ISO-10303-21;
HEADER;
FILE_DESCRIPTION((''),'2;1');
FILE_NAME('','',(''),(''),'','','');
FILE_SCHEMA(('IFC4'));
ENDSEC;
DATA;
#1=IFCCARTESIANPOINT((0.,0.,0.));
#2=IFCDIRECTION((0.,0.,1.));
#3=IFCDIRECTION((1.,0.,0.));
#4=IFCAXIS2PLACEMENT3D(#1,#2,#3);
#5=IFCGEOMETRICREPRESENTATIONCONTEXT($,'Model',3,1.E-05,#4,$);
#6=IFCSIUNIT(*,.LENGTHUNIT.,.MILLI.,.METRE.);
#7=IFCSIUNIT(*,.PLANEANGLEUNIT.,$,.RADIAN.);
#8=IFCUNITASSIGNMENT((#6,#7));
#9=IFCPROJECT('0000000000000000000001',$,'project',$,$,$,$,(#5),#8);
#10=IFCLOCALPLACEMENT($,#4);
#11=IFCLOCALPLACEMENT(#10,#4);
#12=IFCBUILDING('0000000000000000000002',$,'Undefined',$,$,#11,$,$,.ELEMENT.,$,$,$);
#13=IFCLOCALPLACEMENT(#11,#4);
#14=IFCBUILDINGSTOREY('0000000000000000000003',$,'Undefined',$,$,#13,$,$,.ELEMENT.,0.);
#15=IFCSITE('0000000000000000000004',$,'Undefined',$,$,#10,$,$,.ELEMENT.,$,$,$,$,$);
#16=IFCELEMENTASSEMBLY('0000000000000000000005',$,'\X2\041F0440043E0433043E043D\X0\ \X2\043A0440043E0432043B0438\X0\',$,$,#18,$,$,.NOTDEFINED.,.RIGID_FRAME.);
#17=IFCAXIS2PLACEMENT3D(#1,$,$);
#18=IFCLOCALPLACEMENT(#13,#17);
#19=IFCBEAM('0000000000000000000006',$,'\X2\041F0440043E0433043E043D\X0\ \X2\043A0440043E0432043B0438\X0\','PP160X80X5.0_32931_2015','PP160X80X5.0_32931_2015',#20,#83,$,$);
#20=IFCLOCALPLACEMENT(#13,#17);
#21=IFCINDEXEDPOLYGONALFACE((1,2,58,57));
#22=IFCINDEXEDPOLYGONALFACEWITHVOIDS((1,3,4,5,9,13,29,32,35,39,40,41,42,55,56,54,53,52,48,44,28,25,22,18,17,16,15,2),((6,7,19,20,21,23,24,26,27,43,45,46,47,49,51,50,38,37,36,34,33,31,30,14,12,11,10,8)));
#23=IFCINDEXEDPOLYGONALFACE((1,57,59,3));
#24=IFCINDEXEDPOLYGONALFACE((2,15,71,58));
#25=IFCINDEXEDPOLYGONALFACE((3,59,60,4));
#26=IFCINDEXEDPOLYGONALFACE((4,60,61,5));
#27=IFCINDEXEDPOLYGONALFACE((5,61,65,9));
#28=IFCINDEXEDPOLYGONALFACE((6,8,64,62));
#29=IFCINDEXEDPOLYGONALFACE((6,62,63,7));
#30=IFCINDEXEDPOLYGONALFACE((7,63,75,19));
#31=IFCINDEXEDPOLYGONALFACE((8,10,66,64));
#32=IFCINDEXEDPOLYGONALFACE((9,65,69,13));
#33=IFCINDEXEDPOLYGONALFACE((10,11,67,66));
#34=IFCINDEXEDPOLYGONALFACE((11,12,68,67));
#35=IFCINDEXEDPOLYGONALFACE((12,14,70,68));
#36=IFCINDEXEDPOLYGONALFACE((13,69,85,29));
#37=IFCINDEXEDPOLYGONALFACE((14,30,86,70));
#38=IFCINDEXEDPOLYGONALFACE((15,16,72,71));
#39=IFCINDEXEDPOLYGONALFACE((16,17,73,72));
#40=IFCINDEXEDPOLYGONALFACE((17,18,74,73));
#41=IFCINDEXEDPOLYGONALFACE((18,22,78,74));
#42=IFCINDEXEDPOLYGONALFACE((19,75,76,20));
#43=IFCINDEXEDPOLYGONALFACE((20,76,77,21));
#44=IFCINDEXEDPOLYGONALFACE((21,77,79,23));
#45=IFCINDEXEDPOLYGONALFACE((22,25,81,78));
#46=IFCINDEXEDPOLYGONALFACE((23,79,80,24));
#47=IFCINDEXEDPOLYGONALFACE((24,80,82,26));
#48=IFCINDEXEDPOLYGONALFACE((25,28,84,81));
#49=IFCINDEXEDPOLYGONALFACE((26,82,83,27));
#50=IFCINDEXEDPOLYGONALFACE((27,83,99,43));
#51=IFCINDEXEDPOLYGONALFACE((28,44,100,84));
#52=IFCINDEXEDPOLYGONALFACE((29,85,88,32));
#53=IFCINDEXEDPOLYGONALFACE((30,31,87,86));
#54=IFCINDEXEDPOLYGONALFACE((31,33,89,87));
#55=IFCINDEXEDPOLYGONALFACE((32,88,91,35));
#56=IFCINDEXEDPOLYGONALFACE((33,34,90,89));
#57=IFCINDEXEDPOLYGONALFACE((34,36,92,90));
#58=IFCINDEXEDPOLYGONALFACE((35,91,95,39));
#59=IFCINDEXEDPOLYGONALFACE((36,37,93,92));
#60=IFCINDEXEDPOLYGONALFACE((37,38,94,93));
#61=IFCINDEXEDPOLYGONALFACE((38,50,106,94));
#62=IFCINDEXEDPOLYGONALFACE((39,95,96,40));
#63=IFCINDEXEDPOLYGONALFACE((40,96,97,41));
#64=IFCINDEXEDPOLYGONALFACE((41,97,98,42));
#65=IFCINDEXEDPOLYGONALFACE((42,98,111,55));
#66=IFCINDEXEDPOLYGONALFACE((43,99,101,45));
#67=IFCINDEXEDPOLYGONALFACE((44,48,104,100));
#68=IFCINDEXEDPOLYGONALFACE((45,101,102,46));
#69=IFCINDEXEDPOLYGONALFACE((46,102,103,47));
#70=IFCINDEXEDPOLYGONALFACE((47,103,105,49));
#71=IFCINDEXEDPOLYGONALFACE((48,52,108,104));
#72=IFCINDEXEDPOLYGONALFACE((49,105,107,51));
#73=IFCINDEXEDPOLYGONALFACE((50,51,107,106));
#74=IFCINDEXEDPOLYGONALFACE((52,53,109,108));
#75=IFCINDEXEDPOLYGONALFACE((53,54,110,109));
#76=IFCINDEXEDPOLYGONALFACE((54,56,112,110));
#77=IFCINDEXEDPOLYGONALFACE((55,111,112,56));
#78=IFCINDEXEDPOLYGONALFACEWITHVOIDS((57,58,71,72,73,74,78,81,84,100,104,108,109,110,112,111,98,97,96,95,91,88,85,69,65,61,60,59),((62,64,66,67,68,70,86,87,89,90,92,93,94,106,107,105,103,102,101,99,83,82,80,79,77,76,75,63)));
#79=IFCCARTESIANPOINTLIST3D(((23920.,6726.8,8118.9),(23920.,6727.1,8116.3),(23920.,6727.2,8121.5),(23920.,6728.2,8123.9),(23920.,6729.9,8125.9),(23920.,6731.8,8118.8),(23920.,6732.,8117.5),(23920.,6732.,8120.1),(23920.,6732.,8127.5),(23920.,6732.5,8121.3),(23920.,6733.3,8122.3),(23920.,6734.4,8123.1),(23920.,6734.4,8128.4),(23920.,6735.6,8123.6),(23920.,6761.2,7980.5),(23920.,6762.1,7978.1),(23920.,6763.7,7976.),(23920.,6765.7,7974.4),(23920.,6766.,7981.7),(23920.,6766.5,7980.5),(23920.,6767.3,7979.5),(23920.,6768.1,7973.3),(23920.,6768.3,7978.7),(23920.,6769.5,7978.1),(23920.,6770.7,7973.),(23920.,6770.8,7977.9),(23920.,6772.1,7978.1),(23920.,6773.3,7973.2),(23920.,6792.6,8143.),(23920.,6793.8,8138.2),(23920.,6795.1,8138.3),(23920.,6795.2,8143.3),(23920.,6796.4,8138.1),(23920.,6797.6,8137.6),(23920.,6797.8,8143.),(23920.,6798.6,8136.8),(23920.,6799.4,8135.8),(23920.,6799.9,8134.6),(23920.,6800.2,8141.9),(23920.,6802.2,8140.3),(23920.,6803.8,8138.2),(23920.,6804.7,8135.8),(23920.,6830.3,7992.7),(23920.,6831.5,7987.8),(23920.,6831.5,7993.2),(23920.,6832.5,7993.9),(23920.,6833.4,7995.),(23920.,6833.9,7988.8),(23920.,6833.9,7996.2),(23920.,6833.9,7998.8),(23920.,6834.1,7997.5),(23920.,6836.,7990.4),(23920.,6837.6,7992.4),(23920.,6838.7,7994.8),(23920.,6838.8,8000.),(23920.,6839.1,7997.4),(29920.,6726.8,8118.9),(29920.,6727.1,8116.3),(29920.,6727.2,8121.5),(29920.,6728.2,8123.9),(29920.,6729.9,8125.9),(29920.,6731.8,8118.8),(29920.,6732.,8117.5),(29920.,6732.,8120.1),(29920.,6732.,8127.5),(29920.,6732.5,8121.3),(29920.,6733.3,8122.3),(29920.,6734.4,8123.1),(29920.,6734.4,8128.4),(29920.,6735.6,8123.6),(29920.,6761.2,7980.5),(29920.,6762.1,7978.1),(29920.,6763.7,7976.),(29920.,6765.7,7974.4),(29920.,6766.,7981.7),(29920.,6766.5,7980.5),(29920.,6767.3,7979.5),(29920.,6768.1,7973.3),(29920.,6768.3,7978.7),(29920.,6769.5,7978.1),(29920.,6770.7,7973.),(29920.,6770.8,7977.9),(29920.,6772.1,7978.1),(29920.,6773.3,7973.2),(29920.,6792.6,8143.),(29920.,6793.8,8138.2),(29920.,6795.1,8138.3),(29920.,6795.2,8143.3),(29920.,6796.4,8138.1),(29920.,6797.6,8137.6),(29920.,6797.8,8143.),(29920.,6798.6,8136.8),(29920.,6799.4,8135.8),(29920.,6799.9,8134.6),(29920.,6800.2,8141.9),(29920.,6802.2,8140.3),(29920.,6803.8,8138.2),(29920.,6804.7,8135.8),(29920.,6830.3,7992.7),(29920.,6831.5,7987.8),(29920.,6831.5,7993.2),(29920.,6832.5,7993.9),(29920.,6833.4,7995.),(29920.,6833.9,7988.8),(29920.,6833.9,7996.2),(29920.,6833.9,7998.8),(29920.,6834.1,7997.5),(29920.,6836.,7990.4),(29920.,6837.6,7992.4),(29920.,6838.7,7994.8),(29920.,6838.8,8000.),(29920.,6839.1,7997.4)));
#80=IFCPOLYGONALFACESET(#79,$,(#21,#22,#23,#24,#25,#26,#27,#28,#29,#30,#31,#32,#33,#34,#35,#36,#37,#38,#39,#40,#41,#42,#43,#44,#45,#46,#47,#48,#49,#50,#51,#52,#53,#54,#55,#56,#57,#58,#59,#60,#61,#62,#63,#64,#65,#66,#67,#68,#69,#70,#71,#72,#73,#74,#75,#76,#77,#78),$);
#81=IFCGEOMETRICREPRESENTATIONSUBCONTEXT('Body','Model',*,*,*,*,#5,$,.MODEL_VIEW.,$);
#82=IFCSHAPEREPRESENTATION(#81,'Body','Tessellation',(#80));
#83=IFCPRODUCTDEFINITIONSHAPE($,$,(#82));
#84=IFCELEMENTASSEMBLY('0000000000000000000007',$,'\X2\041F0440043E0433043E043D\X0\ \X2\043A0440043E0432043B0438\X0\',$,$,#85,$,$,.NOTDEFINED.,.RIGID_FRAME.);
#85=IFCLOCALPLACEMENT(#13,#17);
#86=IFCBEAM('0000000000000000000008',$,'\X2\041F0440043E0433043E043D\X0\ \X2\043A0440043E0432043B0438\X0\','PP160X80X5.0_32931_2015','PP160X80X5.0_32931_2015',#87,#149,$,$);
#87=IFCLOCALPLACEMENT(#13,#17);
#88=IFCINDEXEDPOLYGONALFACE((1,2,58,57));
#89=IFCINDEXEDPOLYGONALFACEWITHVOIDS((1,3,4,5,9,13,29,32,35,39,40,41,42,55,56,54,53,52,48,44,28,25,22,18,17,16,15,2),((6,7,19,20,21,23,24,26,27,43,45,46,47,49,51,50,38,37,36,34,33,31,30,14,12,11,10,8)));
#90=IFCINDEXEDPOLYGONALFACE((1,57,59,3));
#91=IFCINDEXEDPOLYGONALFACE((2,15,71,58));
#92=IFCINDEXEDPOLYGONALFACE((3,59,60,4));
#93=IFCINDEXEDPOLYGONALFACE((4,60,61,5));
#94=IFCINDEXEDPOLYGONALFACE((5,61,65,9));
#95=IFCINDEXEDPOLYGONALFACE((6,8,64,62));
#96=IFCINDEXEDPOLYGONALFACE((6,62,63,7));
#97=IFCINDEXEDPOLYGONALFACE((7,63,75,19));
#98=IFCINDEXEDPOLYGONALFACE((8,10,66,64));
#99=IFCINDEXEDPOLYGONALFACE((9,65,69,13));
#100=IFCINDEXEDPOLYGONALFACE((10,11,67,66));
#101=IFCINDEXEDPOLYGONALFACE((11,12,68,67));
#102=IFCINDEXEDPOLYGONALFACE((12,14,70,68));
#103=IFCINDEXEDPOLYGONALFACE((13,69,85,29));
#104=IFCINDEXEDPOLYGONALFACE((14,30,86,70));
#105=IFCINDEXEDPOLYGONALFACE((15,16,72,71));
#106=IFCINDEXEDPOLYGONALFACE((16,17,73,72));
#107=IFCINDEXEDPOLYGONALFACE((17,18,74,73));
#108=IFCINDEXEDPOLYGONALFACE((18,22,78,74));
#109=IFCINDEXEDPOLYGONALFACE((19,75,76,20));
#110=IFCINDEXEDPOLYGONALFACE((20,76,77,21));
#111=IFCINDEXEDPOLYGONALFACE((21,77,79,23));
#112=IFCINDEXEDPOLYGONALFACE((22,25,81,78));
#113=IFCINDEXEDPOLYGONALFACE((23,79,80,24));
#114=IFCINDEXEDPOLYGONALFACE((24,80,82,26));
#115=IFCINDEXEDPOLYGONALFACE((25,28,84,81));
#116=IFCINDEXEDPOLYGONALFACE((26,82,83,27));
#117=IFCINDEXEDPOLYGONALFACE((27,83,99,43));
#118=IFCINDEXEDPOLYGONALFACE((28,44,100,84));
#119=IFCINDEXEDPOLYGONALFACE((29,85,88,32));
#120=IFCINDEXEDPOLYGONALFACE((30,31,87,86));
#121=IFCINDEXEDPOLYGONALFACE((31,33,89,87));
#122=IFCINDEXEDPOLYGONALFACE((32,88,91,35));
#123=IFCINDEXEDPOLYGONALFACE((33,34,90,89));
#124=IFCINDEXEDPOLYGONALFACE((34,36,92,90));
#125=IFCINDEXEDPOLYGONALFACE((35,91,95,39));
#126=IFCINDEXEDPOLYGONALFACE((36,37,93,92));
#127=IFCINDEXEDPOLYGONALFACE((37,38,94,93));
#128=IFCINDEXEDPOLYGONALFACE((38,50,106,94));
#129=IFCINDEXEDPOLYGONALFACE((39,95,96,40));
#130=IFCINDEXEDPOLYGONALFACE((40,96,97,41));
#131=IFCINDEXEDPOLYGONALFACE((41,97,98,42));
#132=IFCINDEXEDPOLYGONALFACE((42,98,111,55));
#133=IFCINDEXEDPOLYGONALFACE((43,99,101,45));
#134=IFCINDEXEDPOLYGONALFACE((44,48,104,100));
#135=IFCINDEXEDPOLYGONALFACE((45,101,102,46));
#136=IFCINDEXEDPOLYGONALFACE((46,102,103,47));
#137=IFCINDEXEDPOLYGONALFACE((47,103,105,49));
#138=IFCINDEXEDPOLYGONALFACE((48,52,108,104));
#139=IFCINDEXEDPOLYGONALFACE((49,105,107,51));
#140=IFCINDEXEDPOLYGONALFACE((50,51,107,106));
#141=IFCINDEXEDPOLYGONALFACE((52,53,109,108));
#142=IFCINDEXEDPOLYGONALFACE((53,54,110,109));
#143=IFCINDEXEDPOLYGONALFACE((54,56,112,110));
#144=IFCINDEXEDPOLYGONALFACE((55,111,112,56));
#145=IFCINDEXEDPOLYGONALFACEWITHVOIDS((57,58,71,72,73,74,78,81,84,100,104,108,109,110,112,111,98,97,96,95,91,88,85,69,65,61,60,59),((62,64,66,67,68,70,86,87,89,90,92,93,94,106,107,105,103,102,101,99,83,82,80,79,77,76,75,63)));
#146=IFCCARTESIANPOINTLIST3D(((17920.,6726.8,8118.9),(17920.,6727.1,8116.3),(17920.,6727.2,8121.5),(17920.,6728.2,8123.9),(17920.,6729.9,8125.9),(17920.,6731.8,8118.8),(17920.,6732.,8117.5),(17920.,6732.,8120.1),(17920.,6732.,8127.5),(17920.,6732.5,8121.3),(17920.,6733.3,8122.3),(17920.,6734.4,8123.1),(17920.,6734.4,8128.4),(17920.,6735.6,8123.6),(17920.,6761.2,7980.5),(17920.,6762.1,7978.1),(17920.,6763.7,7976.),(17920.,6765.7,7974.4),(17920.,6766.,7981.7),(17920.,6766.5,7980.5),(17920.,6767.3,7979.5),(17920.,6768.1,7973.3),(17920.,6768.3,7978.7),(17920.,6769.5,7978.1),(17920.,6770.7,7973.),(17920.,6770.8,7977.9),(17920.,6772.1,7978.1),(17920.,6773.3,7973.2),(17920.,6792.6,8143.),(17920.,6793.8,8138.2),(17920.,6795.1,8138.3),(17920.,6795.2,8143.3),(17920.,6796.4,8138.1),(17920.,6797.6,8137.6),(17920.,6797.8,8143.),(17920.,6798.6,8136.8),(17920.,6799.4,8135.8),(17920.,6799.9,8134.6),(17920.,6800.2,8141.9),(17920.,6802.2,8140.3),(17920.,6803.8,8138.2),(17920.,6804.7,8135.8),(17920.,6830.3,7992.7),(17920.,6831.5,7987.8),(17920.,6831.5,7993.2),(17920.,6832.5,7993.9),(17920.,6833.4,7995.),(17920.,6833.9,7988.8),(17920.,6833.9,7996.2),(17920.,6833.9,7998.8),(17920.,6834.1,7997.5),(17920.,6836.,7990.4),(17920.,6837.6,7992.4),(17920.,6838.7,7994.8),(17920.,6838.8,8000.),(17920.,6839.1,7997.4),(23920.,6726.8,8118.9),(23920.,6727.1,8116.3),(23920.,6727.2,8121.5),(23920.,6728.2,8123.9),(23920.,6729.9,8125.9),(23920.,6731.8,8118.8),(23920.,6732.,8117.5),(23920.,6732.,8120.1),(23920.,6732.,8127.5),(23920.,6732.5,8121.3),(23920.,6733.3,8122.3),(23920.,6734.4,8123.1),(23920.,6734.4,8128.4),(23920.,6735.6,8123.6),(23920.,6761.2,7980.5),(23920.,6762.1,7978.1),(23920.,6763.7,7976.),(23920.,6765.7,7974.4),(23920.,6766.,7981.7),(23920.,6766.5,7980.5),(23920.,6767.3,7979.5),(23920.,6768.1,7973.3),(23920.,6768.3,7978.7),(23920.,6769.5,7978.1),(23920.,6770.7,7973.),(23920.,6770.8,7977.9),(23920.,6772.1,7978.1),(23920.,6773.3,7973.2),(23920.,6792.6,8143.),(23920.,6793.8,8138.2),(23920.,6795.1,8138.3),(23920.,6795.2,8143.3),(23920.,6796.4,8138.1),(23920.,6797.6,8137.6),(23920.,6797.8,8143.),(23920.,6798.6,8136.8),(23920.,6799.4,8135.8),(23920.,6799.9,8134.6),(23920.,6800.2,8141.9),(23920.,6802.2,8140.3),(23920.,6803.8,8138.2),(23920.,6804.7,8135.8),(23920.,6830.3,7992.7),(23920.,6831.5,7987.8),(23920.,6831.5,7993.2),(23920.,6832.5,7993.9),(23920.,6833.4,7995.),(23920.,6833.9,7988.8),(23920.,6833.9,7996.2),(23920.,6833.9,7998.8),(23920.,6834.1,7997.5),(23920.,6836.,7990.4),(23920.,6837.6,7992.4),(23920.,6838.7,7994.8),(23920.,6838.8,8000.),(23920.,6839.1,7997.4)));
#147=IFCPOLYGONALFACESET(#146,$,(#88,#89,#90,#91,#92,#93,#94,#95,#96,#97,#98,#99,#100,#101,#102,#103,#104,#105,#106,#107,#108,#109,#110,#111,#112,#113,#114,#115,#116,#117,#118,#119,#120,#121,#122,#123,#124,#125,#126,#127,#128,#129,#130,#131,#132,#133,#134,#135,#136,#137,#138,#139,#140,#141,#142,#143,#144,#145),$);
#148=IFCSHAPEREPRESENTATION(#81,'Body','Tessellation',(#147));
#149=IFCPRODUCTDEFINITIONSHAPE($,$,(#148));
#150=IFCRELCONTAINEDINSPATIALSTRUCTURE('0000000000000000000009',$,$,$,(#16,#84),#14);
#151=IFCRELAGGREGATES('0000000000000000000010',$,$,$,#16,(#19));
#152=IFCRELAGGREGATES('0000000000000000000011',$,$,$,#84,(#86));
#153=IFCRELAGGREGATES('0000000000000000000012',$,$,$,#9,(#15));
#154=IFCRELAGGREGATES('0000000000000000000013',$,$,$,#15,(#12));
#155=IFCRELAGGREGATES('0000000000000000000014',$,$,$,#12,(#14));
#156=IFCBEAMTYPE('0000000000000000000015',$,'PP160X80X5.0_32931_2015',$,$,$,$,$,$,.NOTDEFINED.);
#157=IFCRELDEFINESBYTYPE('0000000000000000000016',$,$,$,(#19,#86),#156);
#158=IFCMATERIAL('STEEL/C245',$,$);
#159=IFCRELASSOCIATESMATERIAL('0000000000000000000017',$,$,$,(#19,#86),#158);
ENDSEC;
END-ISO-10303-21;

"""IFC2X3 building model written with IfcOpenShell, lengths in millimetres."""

from ifc_helpers import new_model, si_unit, frame, origin_with_axes, origin_2d_with_axis, place, context, subcontext, project, spatial, hollow_rectangle, extrude, material, type_object, element, aggregate, save


model = new_model("IFC2X3")

# Units and contexts
model_context = context("Model", 3, precision=1e-05, world=origin_with_axes())
body_context = subcontext(model_context, "Body", "Model", "MODEL_VIEW")
ifc_project = project(units=[si_unit("LENGTHUNIT", "METRE", prefix="MILLI"), si_unit("PLANEANGLEUNIT", "RADIAN")], contexts=[model_context])

# Site, building, storey
site_placement = place(None, origin_with_axes())
site = spatial("IfcSite", under=ifc_project, at=site_placement, Name="Undefined", CompositionType="ELEMENT")
building_placement = place(site_placement, origin_with_axes())
building = spatial("IfcBuilding", under=site, at=building_placement, Name="Undefined", CompositionType="ELEMENT")
storey_placement = place(building_placement, origin_with_axes())
storey = spatial("IfcBuildingStorey", under=building, at=storey_placement, Name="Undefined", CompositionType="ELEMENT", Elevation=0.0)

# Shared definitions
ifc_material = material(Name="STEEL/C245")

# Element assemblies, beams
beam_type_1 = type_object("IfcBeamType", Name="PP160X80X5.0_32931_2015", PredefinedType="NOTDEFINED")
assembly_1_placement = place(storey_placement, origin_with_axes())
assembly_1 = element("IfcElementAssembly", 1, at=assembly_1_placement, inside=storey, Name="Прогон кровли", AssemblyPlace="NOTDEFINED", PredefinedType="RIGID_FRAME")
beam_1_placement = place(assembly_1_placement, frame((23920.0, 6782.9, 8058.1), z_axis=(0.0, -0.243188, 0.969979), x_axis=(1.0, 0.0, 0.0)))
beam_1 = element("IfcBeam", 2, at=beam_1_placement, type_object=beam_type_1, material=ifc_material, Name="Прогон кровли", Description="PP160X80X5.0_32931_2015", ObjectType="PP160X80X5.0_32931_2015", context=body_context, shape_type="SweptSolid", body=[
    extrude(hollow_rectangle(XDim=80.0, YDim=160.0, WallThickness=5.0, InnerFilletRadius=5.0, OuterFilletRadius=10.0, at=origin_2d_with_axis()), frame((6000.0, 0.0, 0.0), z_axis=(-1.0, 0.0, 0.0), x_axis=(0.0, -1.0, 0.0)), (0.0, 0.0, 1.0), 6000.0),
])
aggregate(assembly_1, [beam_1])
assembly_2_placement = place(storey_placement, origin_with_axes())
assembly_2 = element("IfcElementAssembly", 3, at=assembly_2_placement, inside=storey, Name="Прогон кровли", AssemblyPlace="NOTDEFINED", PredefinedType="RIGID_FRAME")
beam_2_placement = place(assembly_2_placement, frame((17920.0, 6782.9, 8058.1), z_axis=(0.0, -0.243188, 0.969979), x_axis=(1.0, 0.0, 0.0)))
beam_2 = element("IfcBeam", 4, at=beam_2_placement, type_object=beam_type_1, material=ifc_material, Name="Прогон кровли", Description="PP160X80X5.0_32931_2015", ObjectType="PP160X80X5.0_32931_2015", context=body_context, shape_type="SweptSolid", body=[
    extrude(hollow_rectangle(XDim=80.0, YDim=160.0, WallThickness=5.0, InnerFilletRadius=5.0, OuterFilletRadius=10.0, at=origin_2d_with_axis()), frame((6000.0, 0.0, 0.0), z_axis=(-1.0, 0.0, 0.0), x_axis=(0.0, -1.0, 0.0)), (0.0, 0.0, 1.0), 6000.0),
])
aggregate(assembly_2, [beam_2])

save(model, "model.ifc")
